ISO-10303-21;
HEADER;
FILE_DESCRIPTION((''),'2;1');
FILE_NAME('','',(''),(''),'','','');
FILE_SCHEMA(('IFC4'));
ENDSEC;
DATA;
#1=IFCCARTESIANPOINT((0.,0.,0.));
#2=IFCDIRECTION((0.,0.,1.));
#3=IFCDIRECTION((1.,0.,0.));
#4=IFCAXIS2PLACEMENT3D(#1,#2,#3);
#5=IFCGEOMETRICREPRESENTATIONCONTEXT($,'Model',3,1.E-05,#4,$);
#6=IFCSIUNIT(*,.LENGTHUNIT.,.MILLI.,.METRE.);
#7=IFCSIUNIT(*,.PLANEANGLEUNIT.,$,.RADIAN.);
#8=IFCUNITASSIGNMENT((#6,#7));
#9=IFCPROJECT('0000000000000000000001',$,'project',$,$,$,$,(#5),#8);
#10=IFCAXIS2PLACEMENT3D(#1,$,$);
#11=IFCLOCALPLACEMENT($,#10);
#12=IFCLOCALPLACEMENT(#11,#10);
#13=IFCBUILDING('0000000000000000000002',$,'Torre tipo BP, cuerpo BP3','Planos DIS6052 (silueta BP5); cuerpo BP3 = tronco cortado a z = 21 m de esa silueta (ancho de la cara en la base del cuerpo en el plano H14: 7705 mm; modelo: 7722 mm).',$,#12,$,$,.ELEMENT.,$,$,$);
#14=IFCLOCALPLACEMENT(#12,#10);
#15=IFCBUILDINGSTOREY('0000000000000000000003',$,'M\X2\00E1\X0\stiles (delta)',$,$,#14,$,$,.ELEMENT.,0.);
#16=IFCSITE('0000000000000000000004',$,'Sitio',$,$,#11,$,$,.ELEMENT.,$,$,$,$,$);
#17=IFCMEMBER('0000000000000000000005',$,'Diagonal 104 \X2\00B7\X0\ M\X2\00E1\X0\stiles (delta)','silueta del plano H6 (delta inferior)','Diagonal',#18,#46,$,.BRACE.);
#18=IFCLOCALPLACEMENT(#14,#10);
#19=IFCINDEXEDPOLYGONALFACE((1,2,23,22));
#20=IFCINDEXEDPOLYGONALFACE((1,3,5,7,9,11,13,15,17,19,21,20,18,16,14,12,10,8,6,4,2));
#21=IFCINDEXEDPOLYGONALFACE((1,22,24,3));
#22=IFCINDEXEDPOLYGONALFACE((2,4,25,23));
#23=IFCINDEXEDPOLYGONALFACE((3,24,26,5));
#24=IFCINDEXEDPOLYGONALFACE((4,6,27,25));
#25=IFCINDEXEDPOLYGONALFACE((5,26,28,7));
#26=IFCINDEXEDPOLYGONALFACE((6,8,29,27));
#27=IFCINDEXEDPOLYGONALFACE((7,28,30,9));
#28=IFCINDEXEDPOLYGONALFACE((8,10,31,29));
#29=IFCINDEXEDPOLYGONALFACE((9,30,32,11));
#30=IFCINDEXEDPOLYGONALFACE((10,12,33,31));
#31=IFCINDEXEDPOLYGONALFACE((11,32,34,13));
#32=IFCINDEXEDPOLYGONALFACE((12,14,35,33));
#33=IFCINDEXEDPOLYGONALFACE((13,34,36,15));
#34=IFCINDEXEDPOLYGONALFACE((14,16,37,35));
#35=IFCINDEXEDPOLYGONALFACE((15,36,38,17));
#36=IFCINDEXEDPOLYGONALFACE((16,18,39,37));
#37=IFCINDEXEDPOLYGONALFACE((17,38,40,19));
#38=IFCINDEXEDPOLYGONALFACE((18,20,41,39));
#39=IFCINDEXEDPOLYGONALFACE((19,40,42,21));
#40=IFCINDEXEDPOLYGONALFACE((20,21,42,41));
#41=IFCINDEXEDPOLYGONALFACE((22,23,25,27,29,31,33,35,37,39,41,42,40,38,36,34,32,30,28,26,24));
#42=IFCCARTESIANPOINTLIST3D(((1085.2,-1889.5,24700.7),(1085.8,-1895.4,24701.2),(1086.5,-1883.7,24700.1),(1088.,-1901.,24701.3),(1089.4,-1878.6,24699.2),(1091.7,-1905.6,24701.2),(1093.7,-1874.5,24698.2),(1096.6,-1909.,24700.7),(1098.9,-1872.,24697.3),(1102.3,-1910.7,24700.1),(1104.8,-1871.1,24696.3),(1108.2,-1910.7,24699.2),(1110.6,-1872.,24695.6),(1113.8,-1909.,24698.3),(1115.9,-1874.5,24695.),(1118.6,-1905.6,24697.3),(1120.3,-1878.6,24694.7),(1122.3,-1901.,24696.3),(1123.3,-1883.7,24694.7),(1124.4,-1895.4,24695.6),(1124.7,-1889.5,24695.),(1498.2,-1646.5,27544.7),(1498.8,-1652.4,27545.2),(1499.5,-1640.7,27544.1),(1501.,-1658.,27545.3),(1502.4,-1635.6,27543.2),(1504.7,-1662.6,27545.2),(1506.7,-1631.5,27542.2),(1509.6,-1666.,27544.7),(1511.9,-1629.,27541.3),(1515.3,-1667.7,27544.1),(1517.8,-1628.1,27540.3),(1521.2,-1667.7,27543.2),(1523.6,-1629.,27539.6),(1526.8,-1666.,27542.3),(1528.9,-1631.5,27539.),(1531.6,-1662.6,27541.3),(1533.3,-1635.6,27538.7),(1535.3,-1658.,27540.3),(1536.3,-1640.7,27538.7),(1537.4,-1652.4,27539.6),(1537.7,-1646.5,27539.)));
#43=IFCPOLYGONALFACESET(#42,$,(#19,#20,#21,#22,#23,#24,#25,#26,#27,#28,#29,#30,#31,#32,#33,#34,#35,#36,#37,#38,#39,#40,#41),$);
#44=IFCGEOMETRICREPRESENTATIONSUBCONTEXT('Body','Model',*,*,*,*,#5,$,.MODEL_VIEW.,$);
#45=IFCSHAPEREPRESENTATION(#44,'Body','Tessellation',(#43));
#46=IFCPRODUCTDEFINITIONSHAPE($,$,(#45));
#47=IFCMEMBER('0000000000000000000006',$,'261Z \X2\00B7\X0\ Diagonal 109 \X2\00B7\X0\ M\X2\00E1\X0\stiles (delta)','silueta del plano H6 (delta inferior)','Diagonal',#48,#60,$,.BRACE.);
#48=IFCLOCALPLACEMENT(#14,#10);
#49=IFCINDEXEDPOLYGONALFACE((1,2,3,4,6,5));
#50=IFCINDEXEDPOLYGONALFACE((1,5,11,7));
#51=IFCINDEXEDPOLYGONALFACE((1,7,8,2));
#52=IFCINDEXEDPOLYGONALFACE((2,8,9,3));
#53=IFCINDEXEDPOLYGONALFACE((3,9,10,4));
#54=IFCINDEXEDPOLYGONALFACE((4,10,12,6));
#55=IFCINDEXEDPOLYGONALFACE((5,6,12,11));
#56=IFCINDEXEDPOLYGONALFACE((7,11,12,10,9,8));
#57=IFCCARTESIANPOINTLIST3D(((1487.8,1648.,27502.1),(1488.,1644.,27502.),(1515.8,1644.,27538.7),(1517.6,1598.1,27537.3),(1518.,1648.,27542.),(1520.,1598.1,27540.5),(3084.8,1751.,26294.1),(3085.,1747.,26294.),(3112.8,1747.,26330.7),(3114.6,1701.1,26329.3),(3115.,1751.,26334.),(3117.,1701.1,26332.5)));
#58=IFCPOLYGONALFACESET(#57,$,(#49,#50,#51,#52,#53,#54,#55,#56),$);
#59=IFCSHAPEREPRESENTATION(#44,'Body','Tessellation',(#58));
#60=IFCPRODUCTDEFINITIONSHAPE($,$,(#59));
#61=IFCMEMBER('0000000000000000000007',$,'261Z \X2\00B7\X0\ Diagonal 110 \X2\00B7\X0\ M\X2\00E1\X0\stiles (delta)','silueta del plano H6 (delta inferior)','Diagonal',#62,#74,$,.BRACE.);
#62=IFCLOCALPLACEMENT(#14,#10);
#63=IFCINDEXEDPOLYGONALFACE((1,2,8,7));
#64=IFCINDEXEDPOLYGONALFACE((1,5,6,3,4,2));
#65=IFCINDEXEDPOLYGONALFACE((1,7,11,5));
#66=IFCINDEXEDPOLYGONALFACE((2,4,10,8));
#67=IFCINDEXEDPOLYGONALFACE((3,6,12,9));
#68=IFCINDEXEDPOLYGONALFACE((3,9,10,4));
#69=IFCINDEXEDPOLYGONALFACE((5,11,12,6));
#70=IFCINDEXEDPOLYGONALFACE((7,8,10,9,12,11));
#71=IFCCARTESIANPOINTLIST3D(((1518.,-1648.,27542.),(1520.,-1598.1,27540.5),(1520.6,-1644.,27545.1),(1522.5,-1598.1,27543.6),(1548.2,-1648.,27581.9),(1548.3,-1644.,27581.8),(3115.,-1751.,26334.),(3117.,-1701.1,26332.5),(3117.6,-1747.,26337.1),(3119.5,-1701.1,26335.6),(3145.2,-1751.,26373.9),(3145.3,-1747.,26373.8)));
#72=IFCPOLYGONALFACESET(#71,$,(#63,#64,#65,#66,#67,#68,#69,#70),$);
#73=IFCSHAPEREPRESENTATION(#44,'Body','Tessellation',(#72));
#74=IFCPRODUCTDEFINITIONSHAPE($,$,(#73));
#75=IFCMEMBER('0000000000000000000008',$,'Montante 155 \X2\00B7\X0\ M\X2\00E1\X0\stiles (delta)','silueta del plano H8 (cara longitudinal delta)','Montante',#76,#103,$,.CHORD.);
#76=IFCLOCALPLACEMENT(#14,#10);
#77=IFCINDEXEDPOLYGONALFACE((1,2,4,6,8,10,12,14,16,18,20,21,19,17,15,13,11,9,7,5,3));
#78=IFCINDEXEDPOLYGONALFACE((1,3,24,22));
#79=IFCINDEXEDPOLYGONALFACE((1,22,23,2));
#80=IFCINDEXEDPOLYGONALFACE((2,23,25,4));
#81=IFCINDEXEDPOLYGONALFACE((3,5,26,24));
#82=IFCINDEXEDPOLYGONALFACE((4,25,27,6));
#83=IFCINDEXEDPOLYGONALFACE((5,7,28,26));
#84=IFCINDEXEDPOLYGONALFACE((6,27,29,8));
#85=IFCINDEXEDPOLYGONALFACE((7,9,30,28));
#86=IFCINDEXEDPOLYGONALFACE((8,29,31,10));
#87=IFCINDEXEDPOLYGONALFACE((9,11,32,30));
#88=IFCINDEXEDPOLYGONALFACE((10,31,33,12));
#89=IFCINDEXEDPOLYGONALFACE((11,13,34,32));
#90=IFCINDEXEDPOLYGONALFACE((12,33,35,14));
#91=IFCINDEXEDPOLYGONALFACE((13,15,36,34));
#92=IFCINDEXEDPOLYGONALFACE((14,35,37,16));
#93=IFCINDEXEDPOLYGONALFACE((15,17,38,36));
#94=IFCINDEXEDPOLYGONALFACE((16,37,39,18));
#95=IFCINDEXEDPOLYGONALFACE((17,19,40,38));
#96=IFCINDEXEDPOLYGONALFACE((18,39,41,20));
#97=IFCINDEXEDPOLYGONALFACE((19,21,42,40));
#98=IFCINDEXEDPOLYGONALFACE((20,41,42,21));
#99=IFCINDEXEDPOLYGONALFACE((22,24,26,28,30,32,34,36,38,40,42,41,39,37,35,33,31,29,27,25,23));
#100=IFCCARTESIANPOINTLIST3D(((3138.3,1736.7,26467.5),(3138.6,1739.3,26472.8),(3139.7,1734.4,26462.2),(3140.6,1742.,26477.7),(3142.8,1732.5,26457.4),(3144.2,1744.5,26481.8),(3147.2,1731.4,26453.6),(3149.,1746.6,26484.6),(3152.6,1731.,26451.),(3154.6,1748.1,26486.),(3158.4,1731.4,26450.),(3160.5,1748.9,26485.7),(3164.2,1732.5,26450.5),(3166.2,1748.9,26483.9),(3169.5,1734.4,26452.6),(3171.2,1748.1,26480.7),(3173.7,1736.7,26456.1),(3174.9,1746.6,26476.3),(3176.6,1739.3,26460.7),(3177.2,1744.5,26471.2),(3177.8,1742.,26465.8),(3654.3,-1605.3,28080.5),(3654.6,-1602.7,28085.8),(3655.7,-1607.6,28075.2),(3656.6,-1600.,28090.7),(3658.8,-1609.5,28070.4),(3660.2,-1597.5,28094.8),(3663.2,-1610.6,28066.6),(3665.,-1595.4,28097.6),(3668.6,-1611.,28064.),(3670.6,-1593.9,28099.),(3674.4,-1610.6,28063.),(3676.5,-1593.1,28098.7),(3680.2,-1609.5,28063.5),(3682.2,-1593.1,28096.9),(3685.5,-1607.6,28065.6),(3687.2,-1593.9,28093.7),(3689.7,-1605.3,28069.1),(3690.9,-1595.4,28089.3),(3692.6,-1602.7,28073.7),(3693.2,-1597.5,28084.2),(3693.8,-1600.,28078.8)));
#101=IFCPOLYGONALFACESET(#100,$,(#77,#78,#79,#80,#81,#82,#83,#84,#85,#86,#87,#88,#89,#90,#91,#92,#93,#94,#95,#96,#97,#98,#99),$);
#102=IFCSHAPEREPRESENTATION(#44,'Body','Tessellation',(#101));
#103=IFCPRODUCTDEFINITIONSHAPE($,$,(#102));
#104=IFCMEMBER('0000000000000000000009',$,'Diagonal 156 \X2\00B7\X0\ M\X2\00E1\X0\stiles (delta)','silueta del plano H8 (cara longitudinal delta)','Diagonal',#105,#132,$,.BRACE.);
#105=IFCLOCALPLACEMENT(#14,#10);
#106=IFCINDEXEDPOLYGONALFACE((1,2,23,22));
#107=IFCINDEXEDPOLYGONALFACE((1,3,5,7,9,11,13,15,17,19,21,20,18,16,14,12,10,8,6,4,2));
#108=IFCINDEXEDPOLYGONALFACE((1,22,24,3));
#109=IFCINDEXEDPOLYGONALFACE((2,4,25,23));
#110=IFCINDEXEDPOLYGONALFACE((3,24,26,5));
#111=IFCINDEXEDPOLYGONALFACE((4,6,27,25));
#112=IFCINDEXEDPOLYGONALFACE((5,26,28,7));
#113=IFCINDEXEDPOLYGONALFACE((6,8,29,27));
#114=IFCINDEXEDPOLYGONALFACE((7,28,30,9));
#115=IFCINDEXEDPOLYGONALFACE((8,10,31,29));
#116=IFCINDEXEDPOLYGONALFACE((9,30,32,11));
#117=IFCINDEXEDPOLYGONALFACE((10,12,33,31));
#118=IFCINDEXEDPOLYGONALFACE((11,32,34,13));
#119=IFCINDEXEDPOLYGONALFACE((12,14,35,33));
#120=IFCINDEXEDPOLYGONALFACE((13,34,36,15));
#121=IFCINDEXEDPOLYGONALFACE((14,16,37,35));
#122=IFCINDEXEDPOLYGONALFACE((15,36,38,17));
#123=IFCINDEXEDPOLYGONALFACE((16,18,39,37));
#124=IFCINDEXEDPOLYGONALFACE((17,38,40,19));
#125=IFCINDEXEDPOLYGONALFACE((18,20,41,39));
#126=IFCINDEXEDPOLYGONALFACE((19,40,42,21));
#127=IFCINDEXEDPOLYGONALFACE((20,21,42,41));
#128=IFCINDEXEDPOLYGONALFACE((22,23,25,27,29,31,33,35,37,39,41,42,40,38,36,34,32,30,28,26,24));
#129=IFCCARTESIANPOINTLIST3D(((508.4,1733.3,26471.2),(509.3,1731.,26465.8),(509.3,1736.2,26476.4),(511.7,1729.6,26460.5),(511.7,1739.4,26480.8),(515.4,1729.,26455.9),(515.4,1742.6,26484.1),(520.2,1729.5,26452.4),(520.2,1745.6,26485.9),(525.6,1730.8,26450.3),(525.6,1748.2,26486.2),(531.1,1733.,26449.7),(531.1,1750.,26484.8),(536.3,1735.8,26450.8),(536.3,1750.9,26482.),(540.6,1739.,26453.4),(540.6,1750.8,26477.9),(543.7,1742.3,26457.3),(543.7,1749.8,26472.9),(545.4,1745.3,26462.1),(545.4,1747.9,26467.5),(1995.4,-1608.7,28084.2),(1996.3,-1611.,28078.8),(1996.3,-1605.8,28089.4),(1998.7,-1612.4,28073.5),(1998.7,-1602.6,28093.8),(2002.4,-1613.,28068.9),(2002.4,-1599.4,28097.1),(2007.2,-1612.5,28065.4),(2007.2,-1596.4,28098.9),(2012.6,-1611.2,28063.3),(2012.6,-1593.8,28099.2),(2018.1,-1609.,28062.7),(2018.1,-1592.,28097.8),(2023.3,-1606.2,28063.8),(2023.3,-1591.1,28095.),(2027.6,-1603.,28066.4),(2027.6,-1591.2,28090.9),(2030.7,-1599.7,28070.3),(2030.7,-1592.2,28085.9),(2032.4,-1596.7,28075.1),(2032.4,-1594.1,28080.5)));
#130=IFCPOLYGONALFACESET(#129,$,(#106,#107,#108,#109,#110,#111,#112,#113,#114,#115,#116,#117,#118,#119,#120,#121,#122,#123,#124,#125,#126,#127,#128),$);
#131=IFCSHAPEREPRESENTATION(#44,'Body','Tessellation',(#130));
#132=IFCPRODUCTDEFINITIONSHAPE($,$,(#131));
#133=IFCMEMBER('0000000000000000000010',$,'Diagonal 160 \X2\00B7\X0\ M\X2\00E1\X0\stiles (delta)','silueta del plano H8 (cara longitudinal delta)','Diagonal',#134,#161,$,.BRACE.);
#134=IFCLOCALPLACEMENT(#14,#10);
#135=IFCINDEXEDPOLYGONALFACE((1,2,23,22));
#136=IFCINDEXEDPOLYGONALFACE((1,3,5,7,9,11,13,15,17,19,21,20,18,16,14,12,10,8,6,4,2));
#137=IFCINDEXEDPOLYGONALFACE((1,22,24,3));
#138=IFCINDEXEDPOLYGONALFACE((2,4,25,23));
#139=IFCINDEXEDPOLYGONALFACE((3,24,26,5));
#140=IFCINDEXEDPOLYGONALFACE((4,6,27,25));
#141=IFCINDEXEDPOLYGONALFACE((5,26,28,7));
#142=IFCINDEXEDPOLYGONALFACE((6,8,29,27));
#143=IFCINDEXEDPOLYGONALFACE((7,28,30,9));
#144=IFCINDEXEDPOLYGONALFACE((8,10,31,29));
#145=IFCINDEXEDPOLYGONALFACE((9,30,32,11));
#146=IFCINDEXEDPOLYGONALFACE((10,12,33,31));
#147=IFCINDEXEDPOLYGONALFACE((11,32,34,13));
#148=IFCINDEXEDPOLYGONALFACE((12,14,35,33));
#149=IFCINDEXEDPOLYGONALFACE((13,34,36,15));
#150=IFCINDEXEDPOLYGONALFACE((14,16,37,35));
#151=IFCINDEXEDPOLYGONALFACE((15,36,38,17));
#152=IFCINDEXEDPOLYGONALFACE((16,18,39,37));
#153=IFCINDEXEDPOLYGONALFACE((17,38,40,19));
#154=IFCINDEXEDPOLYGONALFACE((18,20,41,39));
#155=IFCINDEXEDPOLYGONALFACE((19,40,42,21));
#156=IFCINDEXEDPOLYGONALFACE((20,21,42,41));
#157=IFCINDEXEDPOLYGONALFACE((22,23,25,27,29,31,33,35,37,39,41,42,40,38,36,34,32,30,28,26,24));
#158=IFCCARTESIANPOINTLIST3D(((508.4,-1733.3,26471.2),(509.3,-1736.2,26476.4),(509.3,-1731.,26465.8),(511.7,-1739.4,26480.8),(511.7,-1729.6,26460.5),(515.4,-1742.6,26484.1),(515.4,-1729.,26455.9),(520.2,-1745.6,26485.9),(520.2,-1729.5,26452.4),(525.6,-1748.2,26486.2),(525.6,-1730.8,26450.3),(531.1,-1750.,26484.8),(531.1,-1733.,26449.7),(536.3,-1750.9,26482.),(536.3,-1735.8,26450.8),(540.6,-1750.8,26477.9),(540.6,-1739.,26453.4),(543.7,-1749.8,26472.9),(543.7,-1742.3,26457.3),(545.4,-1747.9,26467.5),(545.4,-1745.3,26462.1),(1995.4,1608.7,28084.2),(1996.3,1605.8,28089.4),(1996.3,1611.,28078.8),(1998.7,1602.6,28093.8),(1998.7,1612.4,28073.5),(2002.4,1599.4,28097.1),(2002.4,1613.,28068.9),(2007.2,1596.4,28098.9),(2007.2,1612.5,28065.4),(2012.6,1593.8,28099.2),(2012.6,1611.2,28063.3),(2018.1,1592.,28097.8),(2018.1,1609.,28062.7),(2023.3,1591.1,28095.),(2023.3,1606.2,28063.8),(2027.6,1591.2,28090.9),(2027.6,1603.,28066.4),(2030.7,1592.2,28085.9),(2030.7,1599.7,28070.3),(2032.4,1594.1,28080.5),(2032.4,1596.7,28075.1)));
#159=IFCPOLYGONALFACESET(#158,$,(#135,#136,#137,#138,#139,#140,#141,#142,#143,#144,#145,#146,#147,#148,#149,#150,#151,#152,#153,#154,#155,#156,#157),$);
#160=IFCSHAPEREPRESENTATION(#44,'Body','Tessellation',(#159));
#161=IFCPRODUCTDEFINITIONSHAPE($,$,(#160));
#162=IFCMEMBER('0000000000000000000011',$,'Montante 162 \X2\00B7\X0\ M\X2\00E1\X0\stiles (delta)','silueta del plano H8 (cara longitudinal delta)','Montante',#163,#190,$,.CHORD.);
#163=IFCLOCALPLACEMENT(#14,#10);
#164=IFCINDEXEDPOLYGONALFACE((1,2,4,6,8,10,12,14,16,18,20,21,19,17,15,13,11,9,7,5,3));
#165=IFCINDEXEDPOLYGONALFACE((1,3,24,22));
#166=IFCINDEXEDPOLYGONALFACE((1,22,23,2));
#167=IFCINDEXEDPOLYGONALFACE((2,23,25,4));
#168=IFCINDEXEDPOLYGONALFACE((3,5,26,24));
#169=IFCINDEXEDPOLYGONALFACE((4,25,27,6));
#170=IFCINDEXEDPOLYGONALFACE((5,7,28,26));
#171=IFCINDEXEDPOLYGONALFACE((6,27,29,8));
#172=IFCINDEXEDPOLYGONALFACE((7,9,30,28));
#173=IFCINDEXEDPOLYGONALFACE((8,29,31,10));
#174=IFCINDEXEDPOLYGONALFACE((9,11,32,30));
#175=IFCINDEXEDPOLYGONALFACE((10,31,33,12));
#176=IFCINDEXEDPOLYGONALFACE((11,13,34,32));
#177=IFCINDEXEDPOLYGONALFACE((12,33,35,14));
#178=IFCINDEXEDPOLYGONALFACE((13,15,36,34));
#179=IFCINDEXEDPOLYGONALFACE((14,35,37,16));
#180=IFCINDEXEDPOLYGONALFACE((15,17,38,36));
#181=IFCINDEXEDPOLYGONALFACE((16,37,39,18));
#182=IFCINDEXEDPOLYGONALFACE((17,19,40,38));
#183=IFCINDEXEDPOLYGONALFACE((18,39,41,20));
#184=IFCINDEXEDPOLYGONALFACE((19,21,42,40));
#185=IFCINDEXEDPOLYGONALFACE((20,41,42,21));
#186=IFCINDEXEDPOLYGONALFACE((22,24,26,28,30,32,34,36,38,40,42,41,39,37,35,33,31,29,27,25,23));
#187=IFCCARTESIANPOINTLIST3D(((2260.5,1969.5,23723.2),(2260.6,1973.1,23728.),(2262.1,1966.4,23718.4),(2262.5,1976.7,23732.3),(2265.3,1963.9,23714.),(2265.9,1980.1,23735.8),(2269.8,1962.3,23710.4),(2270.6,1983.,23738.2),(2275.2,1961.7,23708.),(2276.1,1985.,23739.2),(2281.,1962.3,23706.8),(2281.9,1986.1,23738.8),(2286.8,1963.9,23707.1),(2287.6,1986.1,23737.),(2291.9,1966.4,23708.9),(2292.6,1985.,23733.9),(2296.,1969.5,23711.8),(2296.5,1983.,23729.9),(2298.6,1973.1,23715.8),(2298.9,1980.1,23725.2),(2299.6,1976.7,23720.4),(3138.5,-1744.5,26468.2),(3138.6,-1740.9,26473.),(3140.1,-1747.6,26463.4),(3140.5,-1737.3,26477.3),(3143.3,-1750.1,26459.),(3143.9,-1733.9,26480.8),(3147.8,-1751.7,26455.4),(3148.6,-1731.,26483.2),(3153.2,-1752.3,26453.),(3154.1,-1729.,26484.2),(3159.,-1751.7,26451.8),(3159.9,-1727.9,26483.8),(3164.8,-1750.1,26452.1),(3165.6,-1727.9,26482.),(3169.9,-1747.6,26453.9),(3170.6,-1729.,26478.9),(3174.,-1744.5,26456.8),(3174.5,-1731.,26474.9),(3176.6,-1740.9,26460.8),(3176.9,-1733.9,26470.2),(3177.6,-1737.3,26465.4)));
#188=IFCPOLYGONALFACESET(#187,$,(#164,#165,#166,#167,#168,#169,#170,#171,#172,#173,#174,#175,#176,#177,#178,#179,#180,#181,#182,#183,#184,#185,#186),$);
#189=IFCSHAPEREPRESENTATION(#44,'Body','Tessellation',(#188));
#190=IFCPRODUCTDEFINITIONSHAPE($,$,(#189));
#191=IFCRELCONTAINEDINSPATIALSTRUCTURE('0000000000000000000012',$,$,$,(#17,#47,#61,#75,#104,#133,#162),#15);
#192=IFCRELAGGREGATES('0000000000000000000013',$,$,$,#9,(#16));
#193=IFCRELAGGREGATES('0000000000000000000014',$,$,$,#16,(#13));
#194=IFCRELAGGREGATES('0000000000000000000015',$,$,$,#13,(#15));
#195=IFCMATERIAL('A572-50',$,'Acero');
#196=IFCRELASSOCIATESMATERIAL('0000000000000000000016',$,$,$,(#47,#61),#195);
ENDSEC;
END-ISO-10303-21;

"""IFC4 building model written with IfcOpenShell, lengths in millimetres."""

from ifc_helpers import new_model, si_unit, frame, frame_2d, origin, origin_with_axes, place, context, subcontext, project, spatial, circle, l_section, extrude, material, element, save


model = new_model("IFC4")

# Units and contexts
model_context = context("Model", 3, precision=1e-05, world=origin_with_axes())
body_context = subcontext(model_context, "Body", "Model", "MODEL_VIEW")
ifc_project = project(units=[si_unit("LENGTHUNIT", "METRE", prefix="MILLI"), si_unit("PLANEANGLEUNIT", "RADIAN")], contexts=[model_context])

# Site, building, storey
site_placement = place(None, origin())
site = spatial("IfcSite", under=ifc_project, at=site_placement, Name="Sitio", CompositionType="ELEMENT")
building_placement = place(site_placement, origin())
building = spatial("IfcBuilding", under=site, at=building_placement, Name="Torre tipo BP, cuerpo BP3", Description="Planos DIS6052 (silueta BP5); cuerpo BP3 = tronco cortado a z = 21 m de esa silueta (ancho de la cara en la base del cuerpo en el plano H14: 7705 mm; modelo: 7722 mm).", CompositionType="ELEMENT")
storey_placement = place(building_placement, origin())
storey = spatial("IfcBuildingStorey", under=building, at=storey_placement, Name="Mástiles (delta)", CompositionType="ELEMENT", Elevation=0.0)

# Members
ifc_material = material(Name="A572-50", Category="Acero")
for number, where, z_axis, x_axis, name in (
    (1, (1518.0, -1648.0, 27542.0), (-0.1432, -0.084255, -0.986101), (-0.012108, 0.996444, -0.083381), "Diagonal 104 · Mástiles (delta)"),
):
    element("IfcMember", number, at=place(storey_placement, frame(where, z_axis=z_axis, x_axis=x_axis)), inside=storey, Name=name, Description="silueta del plano H6 (delta inferior)", ObjectType="Diagonal", PredefinedType="BRACE", context=body_context, shape_type="SweptSolid", body=[
        extrude(circle(Radius=20.0), None, (0.0, 0.0, 1.0), 2884.1),
    ])
for number, where, z_axis, x_axis, name in (
    (2, (1518.0, 1648.0, 27542.0), (0.796483, 0.05137, -0.602475), (0.040969, -0.99868, -0.03099), "261Z · Diagonal 109 · Mástiles (delta)"),
    (3, (1518.0, -1648.0, 27542.0), (0.796483, -0.05137, -0.602475), (0.040969, 0.99868, -0.03099), "261Z · Diagonal 110 · Mástiles (delta)"),
):
    element("IfcMember", number, at=place(storey_placement, frame(where, z_axis=z_axis, x_axis=x_axis)), inside=storey, material=ifc_material, Name=name, Description="silueta del plano H6 (delta inferior)", ObjectType="Diagonal", PredefinedType="BRACE", context=body_context, shape_type="SweptSolid", body=[
        extrude(l_section(Depth=50.0, Width=50.0, Thickness=4.0, at=frame_2d((25.0, 25.0))), None, (0.0, 0.0, 1.0), 2005.1),
    ])
member_1_placement = place(storey_placement, frame((3674.0, -1602.0, 28081.0), z_axis=(-0.137725, 0.892009, -0.430524), x_axis=(-0.271786, -0.452017, -0.849596)))
element("IfcMember", 4, at=member_1_placement, inside=storey, Name="Montante 155 · Mástiles (delta)", Description="silueta del plano H8 (cara longitudinal delta)", ObjectType="Montante", PredefinedType="CHORD", context=body_context, shape_type="SweptSolid", body=[
    extrude(circle(Radius=20.0), None, (0.0, 0.0, 1.0), 3746.6),
])
member_2_placement = place(storey_placement, frame((2014.0, -1602.0, 28081.0), z_axis=(-0.37196, 0.835973, -0.403478), x_axis=(-0.928249, -0.334984, 0.161679)))
element("IfcMember", 5, at=member_2_placement, inside=storey, Name="Diagonal 156 · Mástiles (delta)", Description="silueta del plano H8 (cara longitudinal delta)", ObjectType="Diagonal", PredefinedType="BRACE", context=body_context, shape_type="SweptSolid", body=[
    extrude(circle(Radius=20.0), None, (0.0, 0.0, 1.0), 3997.7),
])
member_3_placement = place(storey_placement, frame((2014.0, 1602.0, 28081.0), z_axis=(-0.37196, -0.835973, -0.403478), x_axis=(-0.928249, 0.334984, 0.161679)))
element("IfcMember", 6, at=member_3_placement, inside=storey, Name="Diagonal 160 · Mástiles (delta)", Description="silueta del plano H8 (cara longitudinal delta)", ObjectType="Diagonal", PredefinedType="BRACE", context=body_context, shape_type="SweptSolid", body=[
    extrude(circle(Radius=20.0), None, (0.0, 0.0, 1.0), 3997.7),
])
for number, where, z_axis, x_axis, name in (
    (7, (3158.0, -1740.0, 26468.0), (-0.186767, 0.790039, -0.583914), (-0.240685, -0.613056, -0.752484), "Montante 162 · Mástiles (delta)"),
):
    element("IfcMember", number, at=place(storey_placement, frame(where, z_axis=z_axis, x_axis=x_axis)), inside=storey, Name=name, Description="silueta del plano H8 (cara longitudinal delta)", ObjectType="Montante", PredefinedType="CHORD", context=body_context, shape_type="SweptSolid", body=[
        extrude(circle(Radius=20.0), None, (0.0, 0.0, 1.0), 4701.0),
    ])

save(model, "model.ifc")
